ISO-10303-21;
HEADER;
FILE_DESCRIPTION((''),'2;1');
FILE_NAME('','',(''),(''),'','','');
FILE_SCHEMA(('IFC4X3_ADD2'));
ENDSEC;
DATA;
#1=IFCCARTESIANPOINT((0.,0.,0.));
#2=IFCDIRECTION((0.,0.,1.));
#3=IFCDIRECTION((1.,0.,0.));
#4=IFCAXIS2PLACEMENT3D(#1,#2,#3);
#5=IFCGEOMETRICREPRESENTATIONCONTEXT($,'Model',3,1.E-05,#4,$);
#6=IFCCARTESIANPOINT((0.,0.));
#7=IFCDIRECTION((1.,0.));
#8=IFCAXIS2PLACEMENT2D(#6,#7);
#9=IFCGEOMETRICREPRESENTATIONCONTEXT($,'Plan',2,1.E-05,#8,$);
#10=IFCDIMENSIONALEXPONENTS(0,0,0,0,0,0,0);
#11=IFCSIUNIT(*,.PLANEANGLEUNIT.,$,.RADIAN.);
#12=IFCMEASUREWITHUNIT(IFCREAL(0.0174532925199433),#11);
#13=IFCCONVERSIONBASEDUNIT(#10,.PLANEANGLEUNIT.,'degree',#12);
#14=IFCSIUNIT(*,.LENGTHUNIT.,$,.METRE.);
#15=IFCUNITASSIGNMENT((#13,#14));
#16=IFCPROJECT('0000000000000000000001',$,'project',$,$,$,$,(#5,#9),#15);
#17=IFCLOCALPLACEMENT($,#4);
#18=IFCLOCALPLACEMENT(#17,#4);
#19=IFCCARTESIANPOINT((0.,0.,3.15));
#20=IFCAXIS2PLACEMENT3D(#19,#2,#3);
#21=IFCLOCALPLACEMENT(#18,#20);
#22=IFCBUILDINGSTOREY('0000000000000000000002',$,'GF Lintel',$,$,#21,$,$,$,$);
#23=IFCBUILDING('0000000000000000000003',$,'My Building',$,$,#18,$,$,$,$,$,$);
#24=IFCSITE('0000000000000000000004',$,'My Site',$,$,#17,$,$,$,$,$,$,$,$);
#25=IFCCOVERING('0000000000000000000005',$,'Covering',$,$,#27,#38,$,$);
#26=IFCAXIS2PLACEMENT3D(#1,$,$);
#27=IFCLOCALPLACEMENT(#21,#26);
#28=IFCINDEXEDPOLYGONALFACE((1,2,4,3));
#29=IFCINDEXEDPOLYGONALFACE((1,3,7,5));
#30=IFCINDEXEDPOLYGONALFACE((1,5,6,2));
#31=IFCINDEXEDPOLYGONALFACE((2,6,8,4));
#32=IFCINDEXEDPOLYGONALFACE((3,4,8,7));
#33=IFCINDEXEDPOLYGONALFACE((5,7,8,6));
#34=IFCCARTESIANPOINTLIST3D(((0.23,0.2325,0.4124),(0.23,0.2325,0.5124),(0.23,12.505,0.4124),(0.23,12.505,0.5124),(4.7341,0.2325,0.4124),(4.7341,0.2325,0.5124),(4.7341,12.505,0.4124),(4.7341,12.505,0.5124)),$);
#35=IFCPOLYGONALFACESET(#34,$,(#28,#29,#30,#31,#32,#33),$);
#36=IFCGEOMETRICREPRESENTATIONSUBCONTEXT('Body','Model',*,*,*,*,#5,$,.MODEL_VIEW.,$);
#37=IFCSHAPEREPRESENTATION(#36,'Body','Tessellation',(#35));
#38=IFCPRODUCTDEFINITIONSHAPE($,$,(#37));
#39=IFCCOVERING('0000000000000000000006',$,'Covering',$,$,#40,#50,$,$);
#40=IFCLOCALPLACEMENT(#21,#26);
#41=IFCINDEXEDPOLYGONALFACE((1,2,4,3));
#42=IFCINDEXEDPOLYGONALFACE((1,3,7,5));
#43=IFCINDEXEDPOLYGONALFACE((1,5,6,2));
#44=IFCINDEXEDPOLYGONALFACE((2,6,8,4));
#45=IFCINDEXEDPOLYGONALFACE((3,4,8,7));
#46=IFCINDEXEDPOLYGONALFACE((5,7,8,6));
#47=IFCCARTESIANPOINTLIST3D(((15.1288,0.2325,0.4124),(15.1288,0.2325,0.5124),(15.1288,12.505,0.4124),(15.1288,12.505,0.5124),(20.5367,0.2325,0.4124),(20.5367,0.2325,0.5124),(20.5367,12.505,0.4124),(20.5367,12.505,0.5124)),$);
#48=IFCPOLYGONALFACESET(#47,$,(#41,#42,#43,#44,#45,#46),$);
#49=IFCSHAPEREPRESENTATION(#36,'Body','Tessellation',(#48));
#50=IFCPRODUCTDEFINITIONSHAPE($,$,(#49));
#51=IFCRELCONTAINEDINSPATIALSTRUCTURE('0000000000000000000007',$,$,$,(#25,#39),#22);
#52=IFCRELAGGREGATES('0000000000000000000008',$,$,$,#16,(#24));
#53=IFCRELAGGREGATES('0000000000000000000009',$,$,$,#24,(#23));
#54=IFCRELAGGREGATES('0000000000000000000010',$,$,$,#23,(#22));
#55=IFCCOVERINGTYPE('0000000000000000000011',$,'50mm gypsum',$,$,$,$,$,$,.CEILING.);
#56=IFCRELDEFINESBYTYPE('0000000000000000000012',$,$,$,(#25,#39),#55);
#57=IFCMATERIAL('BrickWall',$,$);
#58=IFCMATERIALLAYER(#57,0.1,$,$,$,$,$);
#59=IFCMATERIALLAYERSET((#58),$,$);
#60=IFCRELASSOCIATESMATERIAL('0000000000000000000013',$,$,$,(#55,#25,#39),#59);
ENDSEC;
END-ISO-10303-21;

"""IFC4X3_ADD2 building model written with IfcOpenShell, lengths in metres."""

from ifc_helpers import new_model, entity, si_unit, converted_unit, frame, origin_with_axes, origin_2d_with_axis, place, context, subcontext, project, spatial, line, indexed_curve, outline, extrude, material, layer, layer_set, layer_usage, type_object, element, save


model = new_model("IFC4X3_ADD2")

# Units and contexts
model_context = context("Model", 3, precision=1e-05, world=origin_with_axes())
plan_context = context("Plan", 2, precision=1e-05, world=origin_2d_with_axis())
body_context = subcontext(model_context, "Body", "Model", "MODEL_VIEW")
ifc_project = project(units=[converted_unit("PLANEANGLEUNIT", "degree", entity("IfcReal", 0.0174532925199433), si_unit("PLANEANGLEUNIT", "RADIAN"), dimensions=[0, 0, 0, 0, 0, 0, 0]), si_unit("LENGTHUNIT", "METRE")], contexts=[model_context, plan_context])

# Site, building, storey
site_placement = place(None, origin_with_axes())
site = spatial("IfcSite", under=ifc_project, at=site_placement, Name="My Site")
building_placement = place(site_placement, origin_with_axes())
building = spatial("IfcBuilding", under=site, at=building_placement, Name="My Building")
storey_placement = place(building_placement, frame((0.0, 0.0, 3.15), z_axis=(0.0, 0.0, 1.0), x_axis=(1.0, 0.0, 0.0)))
storey = spatial("IfcBuildingStorey", under=building, at=storey_placement, Name="GF Lintel")

# Shared definitions
ifc_material = material(Name="BrickWall")

# Coverings
ifc_layer_1 = layer(ifc_material, 0.1)
ifc_layer_set_1 = layer_set([ifc_layer_1])
covering_type = type_object("IfcCoveringType", Name="50mm gypsum", PredefinedType="CEILING", material=ifc_layer_set_1)
ifc_layer_usage_1 = layer_usage(ifc_layer_set_1, "AXIS3", "POSITIVE", 0.0)
covering_1_placement = place(storey_placement, frame((0.23, 12.505, 0.4124), z_axis=(0.0, 0.0, 1.0), x_axis=(0.0, -1.0, 0.0)))
element("IfcCovering", 1, at=covering_1_placement, inside=storey, type_object=covering_type, material=ifc_layer_usage_1, Name="Covering", context=body_context, shape_type="SweptSolid", body=[
    extrude(outline(indexed_curve([(12.2725, 4.5041), (12.2725, 0.0), (0.0, 0.0), (0.0, 4.5041)], segments=[line(4, 1), line(1, 2), line(2, 3), line(3, 4)], self_intersect=False)), None, (0.0, 0.0, 1.0), 0.1),
])
ifc_layer_usage_2 = layer_usage(ifc_layer_set_1, "AXIS3", "POSITIVE", 0.0)
covering_2_placement = place(storey_placement, frame((15.1288, 12.505, 0.4124), z_axis=(0.0, 0.0, 1.0), x_axis=(0.0, -1.0, 0.0)))
element("IfcCovering", 2, at=covering_2_placement, inside=storey, type_object=covering_type, material=ifc_layer_usage_2, Name="Covering", context=body_context, shape_type="SweptSolid", body=[
    extrude(outline(indexed_curve([(0.0, 5.4079), (12.2725, 5.4079), (12.2725, 0.0), (0.0, 0.0)], segments=[line(3, 2), line(2, 1), line(1, 4), line(4, 3)], self_intersect=False)), None, (0.0, 0.0, 1.0), 0.1),
])

save(model, "model.ifc")
